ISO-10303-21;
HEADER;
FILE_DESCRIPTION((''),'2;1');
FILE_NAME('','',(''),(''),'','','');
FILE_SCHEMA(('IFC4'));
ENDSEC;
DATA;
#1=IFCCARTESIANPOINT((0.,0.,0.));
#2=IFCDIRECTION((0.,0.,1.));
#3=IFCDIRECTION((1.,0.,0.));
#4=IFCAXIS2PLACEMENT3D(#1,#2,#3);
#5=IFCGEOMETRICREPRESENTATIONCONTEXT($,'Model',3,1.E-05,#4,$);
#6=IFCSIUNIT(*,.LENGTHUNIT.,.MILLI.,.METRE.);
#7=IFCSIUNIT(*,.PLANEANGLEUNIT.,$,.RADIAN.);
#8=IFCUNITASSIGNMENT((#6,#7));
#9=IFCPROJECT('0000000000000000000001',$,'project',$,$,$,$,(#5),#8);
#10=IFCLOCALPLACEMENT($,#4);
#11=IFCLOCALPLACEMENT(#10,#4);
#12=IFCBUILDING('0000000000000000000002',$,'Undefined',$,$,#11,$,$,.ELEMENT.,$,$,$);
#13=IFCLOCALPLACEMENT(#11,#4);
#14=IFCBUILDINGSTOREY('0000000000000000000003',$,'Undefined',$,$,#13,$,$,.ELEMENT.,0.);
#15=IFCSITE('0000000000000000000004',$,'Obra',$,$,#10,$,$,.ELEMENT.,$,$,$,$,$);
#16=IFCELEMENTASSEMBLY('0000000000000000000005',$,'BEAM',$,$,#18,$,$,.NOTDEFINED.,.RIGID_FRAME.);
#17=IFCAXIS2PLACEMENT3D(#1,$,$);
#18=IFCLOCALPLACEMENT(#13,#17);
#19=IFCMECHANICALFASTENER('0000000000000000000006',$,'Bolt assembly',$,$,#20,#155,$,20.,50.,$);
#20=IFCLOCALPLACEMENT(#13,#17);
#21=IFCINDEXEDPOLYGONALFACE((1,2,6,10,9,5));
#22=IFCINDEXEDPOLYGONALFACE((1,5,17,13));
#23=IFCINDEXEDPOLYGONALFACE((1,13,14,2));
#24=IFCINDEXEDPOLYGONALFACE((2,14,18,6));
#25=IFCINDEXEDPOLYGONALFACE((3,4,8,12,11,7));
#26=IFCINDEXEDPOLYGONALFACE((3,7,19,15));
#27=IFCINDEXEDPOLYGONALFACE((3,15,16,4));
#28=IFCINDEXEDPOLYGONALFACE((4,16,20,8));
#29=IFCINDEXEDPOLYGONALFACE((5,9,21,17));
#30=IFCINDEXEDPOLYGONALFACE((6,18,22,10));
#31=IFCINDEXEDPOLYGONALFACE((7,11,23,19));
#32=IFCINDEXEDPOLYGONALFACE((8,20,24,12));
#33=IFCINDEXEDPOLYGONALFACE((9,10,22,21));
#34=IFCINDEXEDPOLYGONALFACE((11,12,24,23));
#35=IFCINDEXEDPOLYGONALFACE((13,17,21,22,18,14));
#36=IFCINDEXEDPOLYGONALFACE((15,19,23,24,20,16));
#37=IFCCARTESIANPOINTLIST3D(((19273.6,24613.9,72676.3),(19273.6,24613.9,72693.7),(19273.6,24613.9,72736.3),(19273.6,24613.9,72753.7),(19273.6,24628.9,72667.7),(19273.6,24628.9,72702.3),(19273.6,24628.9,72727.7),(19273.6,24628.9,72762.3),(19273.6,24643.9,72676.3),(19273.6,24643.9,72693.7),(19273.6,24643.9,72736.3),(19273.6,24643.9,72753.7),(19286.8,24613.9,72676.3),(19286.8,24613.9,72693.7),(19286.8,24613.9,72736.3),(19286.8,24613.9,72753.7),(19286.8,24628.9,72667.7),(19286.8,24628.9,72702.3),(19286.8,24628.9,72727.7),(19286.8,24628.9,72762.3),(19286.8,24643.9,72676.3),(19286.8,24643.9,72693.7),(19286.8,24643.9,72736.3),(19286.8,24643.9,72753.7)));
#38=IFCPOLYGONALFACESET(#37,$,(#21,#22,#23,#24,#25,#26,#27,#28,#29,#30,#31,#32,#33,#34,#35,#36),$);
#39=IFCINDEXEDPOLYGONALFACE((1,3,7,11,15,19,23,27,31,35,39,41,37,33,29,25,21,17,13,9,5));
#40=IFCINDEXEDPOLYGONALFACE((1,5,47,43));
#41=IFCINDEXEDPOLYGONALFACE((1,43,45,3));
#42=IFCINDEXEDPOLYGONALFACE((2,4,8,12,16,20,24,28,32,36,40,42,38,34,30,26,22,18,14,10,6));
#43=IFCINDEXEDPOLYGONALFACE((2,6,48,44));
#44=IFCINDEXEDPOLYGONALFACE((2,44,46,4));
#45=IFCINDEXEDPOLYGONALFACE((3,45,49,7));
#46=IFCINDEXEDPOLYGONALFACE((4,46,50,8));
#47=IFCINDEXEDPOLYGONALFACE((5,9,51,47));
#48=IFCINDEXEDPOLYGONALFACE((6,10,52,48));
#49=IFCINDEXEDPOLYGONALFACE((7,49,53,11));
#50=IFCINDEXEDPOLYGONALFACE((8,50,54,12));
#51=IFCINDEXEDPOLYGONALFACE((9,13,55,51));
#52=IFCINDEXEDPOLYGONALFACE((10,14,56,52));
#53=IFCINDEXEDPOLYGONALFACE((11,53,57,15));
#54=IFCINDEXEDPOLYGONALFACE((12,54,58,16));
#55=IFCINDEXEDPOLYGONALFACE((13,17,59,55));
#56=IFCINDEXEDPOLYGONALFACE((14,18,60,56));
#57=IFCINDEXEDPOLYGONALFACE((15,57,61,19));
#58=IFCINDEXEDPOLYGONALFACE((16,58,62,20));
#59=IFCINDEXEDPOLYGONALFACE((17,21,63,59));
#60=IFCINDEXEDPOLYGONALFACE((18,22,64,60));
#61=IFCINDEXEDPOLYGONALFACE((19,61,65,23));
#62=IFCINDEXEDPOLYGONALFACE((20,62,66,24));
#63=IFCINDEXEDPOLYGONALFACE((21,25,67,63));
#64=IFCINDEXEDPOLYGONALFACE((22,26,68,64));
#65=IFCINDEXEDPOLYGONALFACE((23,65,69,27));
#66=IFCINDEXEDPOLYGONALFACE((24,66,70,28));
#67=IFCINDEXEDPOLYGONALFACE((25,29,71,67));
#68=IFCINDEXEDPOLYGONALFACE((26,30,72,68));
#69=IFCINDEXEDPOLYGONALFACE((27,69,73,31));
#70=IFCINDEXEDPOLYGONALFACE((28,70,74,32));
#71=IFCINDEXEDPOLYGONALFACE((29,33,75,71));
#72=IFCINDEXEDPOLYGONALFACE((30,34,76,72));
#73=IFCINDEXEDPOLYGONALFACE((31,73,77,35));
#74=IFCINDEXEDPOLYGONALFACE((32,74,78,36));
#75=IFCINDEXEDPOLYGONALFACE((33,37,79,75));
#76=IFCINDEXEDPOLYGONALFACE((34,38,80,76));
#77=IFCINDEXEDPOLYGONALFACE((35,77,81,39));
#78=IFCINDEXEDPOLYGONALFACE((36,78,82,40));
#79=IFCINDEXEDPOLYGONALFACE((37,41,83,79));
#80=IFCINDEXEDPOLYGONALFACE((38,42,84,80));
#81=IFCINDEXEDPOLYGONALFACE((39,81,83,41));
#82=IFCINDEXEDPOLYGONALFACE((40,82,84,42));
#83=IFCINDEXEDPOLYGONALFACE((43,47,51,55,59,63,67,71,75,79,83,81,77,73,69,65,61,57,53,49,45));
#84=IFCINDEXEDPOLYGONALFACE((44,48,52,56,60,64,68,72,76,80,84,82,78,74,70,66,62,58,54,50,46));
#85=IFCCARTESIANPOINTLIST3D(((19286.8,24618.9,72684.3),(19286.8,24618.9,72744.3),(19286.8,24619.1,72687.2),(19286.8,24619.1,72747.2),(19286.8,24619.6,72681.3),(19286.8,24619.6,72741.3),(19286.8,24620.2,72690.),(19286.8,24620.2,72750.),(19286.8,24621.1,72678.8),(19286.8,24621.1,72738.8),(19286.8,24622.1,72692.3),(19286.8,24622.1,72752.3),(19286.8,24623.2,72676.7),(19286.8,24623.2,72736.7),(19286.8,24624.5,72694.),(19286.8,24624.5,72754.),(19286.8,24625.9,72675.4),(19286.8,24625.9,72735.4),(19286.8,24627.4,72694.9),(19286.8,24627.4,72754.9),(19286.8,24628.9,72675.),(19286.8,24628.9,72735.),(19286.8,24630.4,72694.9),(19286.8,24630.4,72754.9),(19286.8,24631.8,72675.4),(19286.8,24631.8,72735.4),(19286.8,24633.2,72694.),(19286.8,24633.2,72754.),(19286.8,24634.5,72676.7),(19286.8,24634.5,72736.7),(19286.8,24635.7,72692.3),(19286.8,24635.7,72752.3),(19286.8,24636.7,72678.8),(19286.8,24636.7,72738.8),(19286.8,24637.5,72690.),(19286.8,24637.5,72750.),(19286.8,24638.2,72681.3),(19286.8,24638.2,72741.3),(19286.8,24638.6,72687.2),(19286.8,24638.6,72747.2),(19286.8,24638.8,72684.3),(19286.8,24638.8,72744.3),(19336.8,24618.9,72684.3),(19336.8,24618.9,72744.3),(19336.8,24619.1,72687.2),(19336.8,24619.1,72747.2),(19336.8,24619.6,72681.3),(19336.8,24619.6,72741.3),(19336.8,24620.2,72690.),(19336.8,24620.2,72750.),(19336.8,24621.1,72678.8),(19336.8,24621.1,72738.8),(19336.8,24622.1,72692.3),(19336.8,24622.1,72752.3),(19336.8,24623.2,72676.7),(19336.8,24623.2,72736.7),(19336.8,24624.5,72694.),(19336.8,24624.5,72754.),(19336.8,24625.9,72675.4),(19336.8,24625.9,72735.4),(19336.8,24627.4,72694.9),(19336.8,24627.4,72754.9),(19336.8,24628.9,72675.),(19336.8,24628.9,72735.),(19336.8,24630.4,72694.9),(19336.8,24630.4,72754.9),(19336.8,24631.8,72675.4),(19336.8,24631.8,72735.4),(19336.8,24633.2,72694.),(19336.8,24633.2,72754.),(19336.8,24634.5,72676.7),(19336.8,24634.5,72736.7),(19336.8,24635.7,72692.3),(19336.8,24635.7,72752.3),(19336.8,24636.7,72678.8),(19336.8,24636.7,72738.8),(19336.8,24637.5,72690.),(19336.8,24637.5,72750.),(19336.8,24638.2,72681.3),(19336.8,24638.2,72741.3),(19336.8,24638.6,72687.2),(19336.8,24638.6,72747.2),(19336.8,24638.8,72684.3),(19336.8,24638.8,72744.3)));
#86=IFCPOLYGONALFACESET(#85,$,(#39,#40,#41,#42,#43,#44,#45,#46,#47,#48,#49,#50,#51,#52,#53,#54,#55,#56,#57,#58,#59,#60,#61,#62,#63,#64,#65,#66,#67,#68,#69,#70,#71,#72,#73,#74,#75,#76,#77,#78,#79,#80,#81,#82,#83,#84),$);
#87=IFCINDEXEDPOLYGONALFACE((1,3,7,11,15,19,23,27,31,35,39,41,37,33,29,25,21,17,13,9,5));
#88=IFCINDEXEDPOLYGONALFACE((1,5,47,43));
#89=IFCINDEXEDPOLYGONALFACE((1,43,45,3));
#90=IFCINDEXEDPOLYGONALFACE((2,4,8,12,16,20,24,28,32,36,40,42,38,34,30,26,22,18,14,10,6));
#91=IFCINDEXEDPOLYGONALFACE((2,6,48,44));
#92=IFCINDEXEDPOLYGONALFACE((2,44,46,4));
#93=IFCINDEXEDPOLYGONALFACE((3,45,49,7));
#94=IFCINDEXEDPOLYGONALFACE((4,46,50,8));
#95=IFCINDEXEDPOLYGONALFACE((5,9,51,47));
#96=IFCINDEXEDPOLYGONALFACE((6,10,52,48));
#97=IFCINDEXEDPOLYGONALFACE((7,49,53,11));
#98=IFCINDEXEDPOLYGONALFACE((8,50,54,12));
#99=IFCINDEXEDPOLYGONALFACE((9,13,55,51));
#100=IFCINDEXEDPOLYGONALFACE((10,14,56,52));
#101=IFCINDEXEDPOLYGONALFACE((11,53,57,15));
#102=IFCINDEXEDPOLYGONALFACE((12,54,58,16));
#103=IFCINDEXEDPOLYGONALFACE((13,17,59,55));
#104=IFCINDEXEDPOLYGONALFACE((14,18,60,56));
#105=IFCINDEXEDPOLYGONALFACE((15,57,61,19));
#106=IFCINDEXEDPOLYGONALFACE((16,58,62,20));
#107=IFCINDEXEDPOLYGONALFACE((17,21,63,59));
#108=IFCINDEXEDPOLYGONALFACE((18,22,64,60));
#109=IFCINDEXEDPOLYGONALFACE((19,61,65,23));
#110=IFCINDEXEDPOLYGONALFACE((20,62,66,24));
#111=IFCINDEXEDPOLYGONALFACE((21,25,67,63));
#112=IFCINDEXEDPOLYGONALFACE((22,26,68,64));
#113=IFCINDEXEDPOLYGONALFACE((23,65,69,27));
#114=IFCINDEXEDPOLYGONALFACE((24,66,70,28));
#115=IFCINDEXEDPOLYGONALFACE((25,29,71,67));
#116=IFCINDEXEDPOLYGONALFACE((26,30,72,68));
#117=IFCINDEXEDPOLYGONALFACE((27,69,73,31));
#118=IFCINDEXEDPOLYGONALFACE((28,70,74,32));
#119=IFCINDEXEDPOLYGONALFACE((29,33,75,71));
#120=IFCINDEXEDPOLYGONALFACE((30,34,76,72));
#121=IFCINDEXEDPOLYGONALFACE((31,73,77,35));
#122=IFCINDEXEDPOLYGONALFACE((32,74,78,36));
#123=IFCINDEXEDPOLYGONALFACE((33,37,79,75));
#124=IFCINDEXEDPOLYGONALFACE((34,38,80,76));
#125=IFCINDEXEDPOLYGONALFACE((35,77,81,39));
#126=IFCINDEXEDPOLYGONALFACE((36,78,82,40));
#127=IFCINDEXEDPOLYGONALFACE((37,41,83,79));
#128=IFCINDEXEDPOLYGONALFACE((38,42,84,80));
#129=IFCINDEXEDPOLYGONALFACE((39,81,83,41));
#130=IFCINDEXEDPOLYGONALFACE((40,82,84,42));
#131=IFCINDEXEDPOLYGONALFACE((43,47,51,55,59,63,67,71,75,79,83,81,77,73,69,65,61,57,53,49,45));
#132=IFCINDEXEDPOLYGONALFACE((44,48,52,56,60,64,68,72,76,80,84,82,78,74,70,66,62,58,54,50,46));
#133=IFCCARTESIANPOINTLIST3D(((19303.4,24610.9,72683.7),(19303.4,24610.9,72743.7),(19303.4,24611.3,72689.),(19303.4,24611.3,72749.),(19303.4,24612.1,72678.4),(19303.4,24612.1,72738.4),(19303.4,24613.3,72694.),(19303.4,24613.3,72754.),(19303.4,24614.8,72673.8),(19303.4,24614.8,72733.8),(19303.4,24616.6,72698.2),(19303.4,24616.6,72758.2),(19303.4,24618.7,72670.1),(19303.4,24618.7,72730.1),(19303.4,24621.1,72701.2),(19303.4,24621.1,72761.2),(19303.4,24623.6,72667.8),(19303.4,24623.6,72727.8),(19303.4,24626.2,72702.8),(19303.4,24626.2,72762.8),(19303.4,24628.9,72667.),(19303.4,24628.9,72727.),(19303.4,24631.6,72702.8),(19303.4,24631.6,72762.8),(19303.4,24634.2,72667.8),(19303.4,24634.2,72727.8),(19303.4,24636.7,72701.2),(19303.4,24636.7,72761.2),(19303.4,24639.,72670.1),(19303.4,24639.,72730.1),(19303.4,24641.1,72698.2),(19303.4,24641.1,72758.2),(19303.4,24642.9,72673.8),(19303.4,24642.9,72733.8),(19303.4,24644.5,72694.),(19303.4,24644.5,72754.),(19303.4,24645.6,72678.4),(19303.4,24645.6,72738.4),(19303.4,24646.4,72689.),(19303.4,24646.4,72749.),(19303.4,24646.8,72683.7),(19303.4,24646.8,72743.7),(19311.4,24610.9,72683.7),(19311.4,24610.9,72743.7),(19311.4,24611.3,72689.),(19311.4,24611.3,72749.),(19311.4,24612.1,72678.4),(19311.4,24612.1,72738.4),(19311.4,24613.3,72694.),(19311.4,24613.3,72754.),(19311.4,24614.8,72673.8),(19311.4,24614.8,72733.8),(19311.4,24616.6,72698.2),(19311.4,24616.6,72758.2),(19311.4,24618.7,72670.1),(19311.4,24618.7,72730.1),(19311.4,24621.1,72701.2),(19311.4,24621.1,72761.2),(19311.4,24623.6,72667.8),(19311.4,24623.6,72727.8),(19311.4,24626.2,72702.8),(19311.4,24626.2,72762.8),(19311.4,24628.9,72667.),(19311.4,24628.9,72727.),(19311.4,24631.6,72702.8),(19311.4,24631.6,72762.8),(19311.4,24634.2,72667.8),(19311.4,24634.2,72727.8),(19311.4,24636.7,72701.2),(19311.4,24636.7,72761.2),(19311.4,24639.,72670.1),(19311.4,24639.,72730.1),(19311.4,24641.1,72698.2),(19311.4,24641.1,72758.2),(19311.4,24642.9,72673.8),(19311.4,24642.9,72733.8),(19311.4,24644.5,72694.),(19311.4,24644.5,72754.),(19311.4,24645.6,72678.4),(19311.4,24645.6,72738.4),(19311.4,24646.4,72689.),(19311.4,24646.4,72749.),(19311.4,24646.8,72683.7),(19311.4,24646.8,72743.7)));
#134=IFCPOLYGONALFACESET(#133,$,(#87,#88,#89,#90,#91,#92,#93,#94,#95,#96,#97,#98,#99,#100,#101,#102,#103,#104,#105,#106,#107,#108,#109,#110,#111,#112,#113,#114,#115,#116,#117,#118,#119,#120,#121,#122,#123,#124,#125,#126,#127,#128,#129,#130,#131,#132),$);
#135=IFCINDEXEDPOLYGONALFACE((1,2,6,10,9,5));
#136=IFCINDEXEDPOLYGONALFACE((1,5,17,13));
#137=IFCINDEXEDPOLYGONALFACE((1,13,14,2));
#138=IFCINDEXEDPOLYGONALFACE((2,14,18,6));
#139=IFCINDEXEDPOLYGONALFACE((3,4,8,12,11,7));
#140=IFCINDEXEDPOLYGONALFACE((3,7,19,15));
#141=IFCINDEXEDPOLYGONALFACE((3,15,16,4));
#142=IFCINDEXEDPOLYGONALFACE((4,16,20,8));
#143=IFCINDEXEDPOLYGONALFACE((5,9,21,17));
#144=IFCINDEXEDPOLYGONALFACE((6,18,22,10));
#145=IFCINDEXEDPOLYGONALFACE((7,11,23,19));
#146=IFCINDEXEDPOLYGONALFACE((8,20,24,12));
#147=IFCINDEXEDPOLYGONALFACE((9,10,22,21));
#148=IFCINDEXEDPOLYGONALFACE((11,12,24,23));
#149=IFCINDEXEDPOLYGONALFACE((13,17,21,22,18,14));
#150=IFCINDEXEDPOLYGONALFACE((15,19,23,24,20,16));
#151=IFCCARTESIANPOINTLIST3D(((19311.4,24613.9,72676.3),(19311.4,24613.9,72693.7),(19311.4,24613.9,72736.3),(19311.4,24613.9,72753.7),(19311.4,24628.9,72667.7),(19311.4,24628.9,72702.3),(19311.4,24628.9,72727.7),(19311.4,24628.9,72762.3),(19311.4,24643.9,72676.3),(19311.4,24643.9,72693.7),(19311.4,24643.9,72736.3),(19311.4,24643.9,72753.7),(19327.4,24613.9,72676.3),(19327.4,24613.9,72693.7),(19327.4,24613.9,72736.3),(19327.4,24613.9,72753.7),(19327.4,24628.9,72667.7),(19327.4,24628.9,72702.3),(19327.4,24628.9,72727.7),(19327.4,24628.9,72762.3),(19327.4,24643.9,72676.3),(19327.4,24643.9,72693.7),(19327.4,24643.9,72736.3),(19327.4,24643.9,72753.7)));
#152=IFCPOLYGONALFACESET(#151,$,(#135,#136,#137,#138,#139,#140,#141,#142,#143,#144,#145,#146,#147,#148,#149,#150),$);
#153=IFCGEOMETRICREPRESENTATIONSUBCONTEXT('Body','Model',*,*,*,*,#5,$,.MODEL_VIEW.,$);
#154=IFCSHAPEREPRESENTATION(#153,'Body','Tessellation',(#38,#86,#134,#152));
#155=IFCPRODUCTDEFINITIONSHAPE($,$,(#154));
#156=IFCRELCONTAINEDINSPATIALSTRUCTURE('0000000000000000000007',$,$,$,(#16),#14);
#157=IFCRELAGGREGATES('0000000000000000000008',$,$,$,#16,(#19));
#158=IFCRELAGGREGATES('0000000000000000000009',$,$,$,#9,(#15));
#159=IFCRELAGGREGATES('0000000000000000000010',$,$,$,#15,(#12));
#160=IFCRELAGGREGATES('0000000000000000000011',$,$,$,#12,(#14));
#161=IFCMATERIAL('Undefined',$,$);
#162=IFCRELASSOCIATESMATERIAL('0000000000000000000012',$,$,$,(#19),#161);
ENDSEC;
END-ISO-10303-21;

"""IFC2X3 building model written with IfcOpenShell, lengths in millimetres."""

from ifc_helpers import new_model, si_unit, frame, origin_with_axes, origin_2d_with_axis, place, context, subcontext, project, spatial, polyline, circle, outline, extrude, source, transform, mapped, material, element, aggregate, save


model = new_model("IFC2X3")

# Units and contexts
model_context = context("Model", 3, precision=1e-05, world=origin_with_axes())
body_context = subcontext(model_context, "Body", "Model", "MODEL_VIEW")
ifc_project = project(units=[si_unit("LENGTHUNIT", "METRE", prefix="MILLI"), si_unit("PLANEANGLEUNIT", "RADIAN")], contexts=[model_context])

# Site, building, storey
site_placement = place(None, origin_with_axes())
site = spatial("IfcSite", under=ifc_project, at=site_placement, Name="Obra", CompositionType="ELEMENT")
building_placement = place(site_placement, origin_with_axes())
building = spatial("IfcBuilding", under=site, at=building_placement, Name="Undefined", CompositionType="ELEMENT")
storey_placement = place(building_placement, origin_with_axes())
storey = spatial("IfcBuildingStorey", under=building, at=storey_placement, Name="Undefined", CompositionType="ELEMENT", Elevation=0.0)

# Shared definitions
ifc_material = material(Name="Undefined")

# Element assembly, mechanical fastener
assembly_1_placement = place(storey_placement, origin_with_axes())
assembly_1 = element("IfcElementAssembly", 1, at=assembly_1_placement, inside=storey, Name="BEAM", AssemblyPlace="NOTDEFINED", PredefinedType="RIGID_FRAME")
shared_shape_1 = source(origin_with_axes(), body_context, "Body", "SweptSolid", [
    extrude(outline(polyline([(17.3, 0.0), (8.7, 15.0), (-8.7, 15.0), (-17.3, 0.0), (-8.7, -15.0), (8.7, -15.0), (17.3, 0.0)])), frame((0.0, -26.5, 0.0), z_axis=(0.0, 1.0, 0.0), x_axis=(1.0, 0.0, 0.0)), (0.0, 0.0, 1.0), 13.2),
    extrude(circle(Radius=10.0, at=origin_2d_with_axis()), frame((0.0, -13.3, 0.0), z_axis=(0.0, 1.0, 0.0), x_axis=(1.0, 0.0, 0.0)), (0.0, 0.0, 1.0), 50.0),
    extrude(circle(Radius=18.0, at=origin_2d_with_axis()), frame((0.0, 3.3, 0.0), z_axis=(0.0, 1.0, 0.0), x_axis=(1.0, 0.0, 0.0)), (0.0, 0.0, 1.0), 8.0),
    extrude(outline(polyline([(17.3, 0.0), (8.7, 15.0), (-8.7, 15.0), (-17.3, 0.0), (-8.7, -15.0), (8.7, -15.0), (17.3, 0.0)])), frame((0.0, 11.3, 0.0), z_axis=(0.0, 1.0, 0.0), x_axis=(1.0, 0.0, 0.0)), (0.0, 0.0, 1.0), 16.0),
])
mechanical_fastener_1_placement = place(assembly_1_placement, frame((19300.1, 24668.9, 72850.0), z_axis=(0.000002, -1.0, 0.0), x_axis=(0.0, 0.0, -1.0)))
mechanical_fastener_1 = element("IfcMechanicalFastener", 2, at=mechanical_fastener_1_placement, material=ifc_material, Name="Bolt assembly", NominalDiameter=20.0, NominalLength=50.0, context=body_context, shape_type="MappedRepresentation", body=[
    mapped(shared_shape_1, transform((105.0, 0.0, 40.0))),
    mapped(shared_shape_1, transform((165.0, 0.0, 40.0))),
])
aggregate(assembly_1, [mechanical_fastener_1])

save(model, "model.ifc")
